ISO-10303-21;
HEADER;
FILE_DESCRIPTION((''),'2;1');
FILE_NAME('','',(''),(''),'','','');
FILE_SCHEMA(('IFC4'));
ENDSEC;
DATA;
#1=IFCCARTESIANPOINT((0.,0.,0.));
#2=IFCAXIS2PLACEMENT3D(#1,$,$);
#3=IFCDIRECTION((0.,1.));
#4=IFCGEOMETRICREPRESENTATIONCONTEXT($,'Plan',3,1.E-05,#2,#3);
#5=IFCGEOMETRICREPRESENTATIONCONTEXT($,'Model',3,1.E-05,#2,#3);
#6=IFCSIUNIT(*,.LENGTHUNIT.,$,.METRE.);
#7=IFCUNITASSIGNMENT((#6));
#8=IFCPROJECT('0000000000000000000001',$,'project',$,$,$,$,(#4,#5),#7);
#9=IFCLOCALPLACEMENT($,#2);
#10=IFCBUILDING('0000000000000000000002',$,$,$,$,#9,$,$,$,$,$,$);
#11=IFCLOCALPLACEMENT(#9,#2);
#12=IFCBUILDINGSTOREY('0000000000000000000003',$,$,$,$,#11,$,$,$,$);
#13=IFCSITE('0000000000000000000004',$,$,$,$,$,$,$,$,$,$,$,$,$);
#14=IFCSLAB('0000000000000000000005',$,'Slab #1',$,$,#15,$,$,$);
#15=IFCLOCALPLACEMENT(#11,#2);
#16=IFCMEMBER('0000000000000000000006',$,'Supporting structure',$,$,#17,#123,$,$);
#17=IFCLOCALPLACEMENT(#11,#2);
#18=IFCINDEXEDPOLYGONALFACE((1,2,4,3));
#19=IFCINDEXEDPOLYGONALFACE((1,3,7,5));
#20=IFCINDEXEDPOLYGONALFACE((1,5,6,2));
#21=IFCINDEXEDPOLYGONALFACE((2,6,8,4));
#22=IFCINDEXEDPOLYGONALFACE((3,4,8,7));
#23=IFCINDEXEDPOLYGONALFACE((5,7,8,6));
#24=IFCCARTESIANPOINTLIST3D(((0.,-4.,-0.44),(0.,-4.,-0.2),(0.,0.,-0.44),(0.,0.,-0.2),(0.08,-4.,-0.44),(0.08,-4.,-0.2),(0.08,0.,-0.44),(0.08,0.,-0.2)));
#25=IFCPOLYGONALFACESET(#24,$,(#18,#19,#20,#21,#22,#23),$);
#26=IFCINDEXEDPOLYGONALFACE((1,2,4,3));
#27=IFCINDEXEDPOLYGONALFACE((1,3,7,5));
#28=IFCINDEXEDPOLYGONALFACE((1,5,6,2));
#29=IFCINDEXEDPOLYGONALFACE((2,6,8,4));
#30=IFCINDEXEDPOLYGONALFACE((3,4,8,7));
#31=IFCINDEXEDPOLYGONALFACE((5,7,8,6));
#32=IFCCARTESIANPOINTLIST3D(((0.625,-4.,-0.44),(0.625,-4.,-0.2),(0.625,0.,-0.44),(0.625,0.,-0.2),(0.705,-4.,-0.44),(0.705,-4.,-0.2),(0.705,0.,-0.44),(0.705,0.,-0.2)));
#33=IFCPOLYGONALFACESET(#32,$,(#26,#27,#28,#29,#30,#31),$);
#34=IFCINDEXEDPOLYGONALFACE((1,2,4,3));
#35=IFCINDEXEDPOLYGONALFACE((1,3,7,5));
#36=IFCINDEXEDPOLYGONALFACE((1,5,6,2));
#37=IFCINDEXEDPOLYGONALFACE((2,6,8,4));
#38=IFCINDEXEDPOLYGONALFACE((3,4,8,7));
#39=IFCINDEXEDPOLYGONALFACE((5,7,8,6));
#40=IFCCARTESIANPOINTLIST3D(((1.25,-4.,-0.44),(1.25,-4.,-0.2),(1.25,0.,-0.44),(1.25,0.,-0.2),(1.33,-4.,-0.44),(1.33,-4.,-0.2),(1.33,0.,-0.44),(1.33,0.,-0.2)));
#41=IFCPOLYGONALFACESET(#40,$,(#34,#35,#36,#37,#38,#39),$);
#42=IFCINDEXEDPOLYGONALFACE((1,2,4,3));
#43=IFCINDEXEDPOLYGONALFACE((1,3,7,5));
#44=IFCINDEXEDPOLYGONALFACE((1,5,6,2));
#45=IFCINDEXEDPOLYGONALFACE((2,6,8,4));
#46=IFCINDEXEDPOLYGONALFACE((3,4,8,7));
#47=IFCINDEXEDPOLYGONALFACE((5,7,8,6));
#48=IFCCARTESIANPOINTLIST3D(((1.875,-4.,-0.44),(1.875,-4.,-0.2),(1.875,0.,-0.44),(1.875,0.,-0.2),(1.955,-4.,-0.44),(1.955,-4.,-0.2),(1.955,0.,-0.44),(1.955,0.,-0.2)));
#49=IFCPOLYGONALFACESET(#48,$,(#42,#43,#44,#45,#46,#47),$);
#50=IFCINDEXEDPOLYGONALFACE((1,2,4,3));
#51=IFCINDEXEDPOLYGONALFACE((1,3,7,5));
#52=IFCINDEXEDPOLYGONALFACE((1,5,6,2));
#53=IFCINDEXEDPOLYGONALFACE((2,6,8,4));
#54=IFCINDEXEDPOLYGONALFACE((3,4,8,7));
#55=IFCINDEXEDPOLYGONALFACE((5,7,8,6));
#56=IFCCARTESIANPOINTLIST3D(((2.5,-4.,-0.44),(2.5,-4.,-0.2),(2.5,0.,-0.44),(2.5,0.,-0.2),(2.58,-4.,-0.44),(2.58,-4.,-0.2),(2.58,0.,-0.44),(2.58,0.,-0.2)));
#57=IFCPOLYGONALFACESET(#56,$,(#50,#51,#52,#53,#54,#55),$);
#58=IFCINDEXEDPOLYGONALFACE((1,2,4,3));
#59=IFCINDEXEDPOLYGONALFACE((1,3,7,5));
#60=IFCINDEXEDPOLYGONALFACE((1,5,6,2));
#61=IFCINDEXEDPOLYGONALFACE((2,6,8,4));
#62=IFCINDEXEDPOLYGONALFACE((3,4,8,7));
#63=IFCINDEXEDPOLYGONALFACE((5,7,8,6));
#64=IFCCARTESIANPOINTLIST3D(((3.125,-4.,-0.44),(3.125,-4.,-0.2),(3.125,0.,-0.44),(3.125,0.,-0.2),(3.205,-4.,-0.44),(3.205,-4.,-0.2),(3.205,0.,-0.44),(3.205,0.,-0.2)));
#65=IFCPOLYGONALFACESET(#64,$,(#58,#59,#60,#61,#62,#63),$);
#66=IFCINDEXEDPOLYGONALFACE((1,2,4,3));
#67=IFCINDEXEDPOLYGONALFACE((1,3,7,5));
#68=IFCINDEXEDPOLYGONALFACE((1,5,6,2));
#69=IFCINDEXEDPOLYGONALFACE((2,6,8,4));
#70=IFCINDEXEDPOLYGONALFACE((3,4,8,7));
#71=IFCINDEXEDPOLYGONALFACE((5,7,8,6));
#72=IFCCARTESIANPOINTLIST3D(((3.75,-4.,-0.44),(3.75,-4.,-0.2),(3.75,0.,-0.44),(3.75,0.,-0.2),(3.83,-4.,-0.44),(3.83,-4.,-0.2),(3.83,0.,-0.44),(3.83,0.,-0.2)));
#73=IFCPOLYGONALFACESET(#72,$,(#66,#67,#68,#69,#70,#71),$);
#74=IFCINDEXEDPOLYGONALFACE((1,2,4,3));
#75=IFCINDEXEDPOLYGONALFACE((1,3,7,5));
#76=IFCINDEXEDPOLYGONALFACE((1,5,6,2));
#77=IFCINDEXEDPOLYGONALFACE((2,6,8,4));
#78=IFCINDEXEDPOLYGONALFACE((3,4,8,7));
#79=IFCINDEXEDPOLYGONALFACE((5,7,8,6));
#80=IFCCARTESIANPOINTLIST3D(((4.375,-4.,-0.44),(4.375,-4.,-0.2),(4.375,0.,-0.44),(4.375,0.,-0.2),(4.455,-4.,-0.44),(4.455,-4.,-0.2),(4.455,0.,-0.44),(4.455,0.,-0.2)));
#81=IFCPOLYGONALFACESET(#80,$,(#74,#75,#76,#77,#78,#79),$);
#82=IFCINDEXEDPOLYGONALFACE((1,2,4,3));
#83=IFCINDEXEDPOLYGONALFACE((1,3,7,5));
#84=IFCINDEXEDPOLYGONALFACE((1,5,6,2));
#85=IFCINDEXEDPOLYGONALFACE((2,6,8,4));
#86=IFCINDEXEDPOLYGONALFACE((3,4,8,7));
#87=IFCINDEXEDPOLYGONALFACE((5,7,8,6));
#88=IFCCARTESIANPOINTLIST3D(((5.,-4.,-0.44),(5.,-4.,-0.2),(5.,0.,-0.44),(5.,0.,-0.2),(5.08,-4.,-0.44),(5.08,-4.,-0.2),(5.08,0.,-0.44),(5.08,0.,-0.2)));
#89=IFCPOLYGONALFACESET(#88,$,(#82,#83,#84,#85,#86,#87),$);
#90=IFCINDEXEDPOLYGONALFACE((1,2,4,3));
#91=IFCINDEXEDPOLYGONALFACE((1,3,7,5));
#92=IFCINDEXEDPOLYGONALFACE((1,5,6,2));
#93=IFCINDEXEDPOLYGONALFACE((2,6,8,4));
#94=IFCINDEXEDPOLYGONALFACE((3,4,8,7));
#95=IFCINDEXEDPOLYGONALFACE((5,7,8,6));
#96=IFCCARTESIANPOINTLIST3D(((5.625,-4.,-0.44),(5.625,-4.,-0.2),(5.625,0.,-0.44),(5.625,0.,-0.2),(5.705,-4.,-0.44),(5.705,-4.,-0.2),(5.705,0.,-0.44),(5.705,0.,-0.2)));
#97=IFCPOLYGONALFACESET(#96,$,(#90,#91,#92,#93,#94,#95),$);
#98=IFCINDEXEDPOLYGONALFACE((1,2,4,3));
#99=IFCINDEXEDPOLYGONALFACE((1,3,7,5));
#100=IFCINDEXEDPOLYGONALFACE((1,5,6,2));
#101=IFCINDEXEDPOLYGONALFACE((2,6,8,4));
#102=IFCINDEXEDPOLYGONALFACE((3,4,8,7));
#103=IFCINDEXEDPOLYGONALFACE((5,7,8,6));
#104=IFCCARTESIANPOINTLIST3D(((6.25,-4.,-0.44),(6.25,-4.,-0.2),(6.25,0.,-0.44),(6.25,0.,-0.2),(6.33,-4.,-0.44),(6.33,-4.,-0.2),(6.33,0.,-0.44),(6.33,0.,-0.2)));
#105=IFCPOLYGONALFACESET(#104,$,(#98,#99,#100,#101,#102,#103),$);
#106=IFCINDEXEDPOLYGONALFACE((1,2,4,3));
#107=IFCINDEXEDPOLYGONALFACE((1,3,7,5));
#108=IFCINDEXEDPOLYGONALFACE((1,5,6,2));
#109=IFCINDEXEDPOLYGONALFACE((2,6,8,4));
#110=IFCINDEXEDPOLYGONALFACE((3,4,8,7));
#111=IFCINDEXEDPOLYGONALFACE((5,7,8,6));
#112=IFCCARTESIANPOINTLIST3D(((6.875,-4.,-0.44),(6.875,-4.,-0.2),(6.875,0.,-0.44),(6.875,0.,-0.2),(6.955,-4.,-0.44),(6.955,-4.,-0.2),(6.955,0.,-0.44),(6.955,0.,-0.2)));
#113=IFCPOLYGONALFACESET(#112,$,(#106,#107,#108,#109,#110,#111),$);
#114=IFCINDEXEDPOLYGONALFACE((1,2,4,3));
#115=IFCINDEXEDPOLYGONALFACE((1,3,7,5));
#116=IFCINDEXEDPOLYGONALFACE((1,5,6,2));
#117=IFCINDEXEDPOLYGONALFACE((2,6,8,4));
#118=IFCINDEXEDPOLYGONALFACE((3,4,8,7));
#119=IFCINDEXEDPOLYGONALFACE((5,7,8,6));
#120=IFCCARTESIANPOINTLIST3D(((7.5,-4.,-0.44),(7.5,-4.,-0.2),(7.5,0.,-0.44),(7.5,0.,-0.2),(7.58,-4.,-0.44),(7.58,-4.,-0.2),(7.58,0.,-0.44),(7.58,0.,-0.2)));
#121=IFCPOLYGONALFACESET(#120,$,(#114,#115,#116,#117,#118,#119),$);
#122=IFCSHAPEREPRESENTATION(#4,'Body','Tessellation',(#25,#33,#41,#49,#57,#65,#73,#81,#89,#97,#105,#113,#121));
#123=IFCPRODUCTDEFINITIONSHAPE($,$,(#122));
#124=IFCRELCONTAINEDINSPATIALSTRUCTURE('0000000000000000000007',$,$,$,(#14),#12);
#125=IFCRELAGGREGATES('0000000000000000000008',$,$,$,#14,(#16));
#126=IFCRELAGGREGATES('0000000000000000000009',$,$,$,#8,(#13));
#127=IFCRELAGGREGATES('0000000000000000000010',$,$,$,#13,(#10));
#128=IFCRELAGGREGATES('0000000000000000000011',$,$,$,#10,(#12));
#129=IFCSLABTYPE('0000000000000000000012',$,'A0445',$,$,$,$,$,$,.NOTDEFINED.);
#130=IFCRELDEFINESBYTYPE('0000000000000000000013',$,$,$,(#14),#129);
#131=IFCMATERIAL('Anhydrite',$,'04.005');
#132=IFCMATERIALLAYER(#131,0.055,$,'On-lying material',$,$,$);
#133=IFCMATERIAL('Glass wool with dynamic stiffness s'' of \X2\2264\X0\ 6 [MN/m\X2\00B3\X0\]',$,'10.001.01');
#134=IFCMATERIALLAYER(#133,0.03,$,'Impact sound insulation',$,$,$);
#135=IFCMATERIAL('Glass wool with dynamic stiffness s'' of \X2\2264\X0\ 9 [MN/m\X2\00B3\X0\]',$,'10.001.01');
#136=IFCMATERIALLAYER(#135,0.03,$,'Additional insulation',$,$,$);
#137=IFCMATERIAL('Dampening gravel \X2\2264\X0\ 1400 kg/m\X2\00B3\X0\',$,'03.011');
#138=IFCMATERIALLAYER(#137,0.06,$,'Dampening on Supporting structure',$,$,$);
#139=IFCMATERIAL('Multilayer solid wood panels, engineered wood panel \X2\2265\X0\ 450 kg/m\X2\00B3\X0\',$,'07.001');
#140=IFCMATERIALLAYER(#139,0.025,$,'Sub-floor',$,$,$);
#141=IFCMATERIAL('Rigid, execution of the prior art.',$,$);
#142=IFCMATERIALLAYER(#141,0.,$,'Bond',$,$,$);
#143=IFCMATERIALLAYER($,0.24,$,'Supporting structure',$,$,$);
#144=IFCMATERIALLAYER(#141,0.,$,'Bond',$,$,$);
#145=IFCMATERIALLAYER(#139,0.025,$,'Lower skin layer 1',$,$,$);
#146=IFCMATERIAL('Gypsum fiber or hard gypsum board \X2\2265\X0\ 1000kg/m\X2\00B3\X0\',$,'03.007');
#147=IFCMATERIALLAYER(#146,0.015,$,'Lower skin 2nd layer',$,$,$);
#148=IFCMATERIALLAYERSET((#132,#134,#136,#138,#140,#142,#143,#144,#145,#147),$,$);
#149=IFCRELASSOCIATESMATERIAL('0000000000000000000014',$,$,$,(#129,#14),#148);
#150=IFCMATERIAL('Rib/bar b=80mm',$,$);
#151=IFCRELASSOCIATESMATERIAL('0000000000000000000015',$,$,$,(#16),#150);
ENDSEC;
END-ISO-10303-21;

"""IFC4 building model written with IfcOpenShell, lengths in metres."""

from ifc_helpers import new_model, si_unit, direction, frame, frame_2d, origin, place, context, project, spatial, rectangle, extrude, material, layer, layer_set, type_object, element, aggregate, save


model = new_model("IFC4")

# Units and contexts
plan_context = context("Plan", 3, precision=1e-05, world=origin(), true_north=direction((0.0, 1.0)))
model_context = context("Model", 3, precision=1e-05, world=origin(), true_north=direction((0.0, 1.0)))
ifc_project = project(units=[si_unit("LENGTHUNIT", "METRE")], contexts=[plan_context, model_context])

# Site, building, storey
site = spatial("IfcSite", under=ifc_project)
building_placement = place(None, origin())
building = spatial("IfcBuilding", under=site, at=building_placement)
storey_placement = place(building_placement, origin())
storey = spatial("IfcBuildingStorey", under=building, at=storey_placement)

# Slab, member
ifc_material_1 = material(Name="Anhydrite", Category="04.005")
ifc_layer_1 = layer(ifc_material_1, 0.055, Name="On-lying material")
ifc_material_2 = material(Name="Glass wool with dynamic stiffness s' of ≤ 6 [MN/m³]", Category="10.001.01")
ifc_layer_2 = layer(ifc_material_2, 0.03, Name="Impact sound insulation")
ifc_material_3 = material(Name="Glass wool with dynamic stiffness s' of ≤ 9 [MN/m³]", Category="10.001.01")
ifc_layer_3 = layer(ifc_material_3, 0.03, Name="Additional insulation")
ifc_material_4 = material(Name="Dampening gravel ≤ 1400 kg/m³", Category="03.011")
ifc_layer_4 = layer(ifc_material_4, 0.06, Name="Dampening on Supporting structure")
ifc_material_5 = material(Name="Multilayer solid wood panels, engineered wood panel ≥ 450 kg/m³", Category="07.001")
ifc_layer_5 = layer(ifc_material_5, 0.025, Name="Sub-floor")
ifc_material_6 = material(Name="Rigid, execution of the prior art.")
ifc_layer_6 = layer(ifc_material_6, 0.0, Name="Bond")
ifc_layer_7 = layer(None, 0.24, Name="Supporting structure")
ifc_layer_8 = layer(ifc_material_6, 0.0, Name="Bond")
ifc_layer_9 = layer(ifc_material_5, 0.025, Name="Lower skin layer 1")
ifc_material_7 = material(Name="Gypsum fiber or hard gypsum board ≥ 1000kg/m³", Category="03.007")
ifc_layer_10 = layer(ifc_material_7, 0.015, Name="Lower skin 2nd layer")
ifc_layer_set = layer_set([ifc_layer_1, ifc_layer_2, ifc_layer_3, ifc_layer_4, ifc_layer_5, ifc_layer_6, ifc_layer_7, ifc_layer_8, ifc_layer_9, ifc_layer_10])
slab_type = type_object("IfcSlabType", Name="A0445", PredefinedType="NOTDEFINED", material=ifc_layer_set)
slab_placement = place(None, frame((0.0, 0.0, 0.0), z_axis=(0.0, 0.0, -1.0), x_axis=(1.0, 0.0, 0.0)))
slab = element("IfcSlab", 1, at=slab_placement, inside=storey, type_object=slab_type, material=ifc_layer_set, Name="Slab #1")
ifc_material_8 = material(Name="Rib/bar b=80mm")
member_1_placement = place(slab_placement, origin())
member_1 = element("IfcMember", 2, at=member_1_placement, material=ifc_material_8, Name="Supporting structure", context=plan_context, shape_type="SweptSolid", body=[
    extrude(rectangle(XDim=0.08, YDim=0.24, at=frame_2d((0.04, 0.12), x_axis=(1.0, 0.0))), frame((0.0, 4.0, 0.2), z_axis=(0.0, -1.0, 0.0), x_axis=(1.0, 0.0, 0.0)), (0.0, 0.0, 1.0), 4.0),
    extrude(rectangle(XDim=0.08, YDim=0.24, at=frame_2d((0.04, 0.12), x_axis=(1.0, 0.0))), frame((0.625, 4.0, 0.2), z_axis=(0.0, -1.0, 0.0), x_axis=(1.0, 0.0, 0.0)), (0.0, 0.0, 1.0), 4.0),
    extrude(rectangle(XDim=0.08, YDim=0.24, at=frame_2d((0.04, 0.12), x_axis=(1.0, 0.0))), frame((1.25, 4.0, 0.2), z_axis=(0.0, -1.0, 0.0), x_axis=(1.0, 0.0, 0.0)), (0.0, 0.0, 1.0), 4.0),
    extrude(rectangle(XDim=0.08, YDim=0.24, at=frame_2d((0.04, 0.12), x_axis=(1.0, 0.0))), frame((1.875, 4.0, 0.2), z_axis=(0.0, -1.0, 0.0), x_axis=(1.0, 0.0, 0.0)), (0.0, 0.0, 1.0), 4.0),
    extrude(rectangle(XDim=0.08, YDim=0.24, at=frame_2d((0.04, 0.12), x_axis=(1.0, 0.0))), frame((2.5, 4.0, 0.2), z_axis=(0.0, -1.0, 0.0), x_axis=(1.0, 0.0, 0.0)), (0.0, 0.0, 1.0), 4.0),
    extrude(rectangle(XDim=0.08, YDim=0.24, at=frame_2d((0.04, 0.12), x_axis=(1.0, 0.0))), frame((3.125, 4.0, 0.2), z_axis=(0.0, -1.0, 0.0), x_axis=(1.0, 0.0, 0.0)), (0.0, 0.0, 1.0), 4.0),
    extrude(rectangle(XDim=0.08, YDim=0.24, at=frame_2d((0.04, 0.12), x_axis=(1.0, 0.0))), frame((3.75, 4.0, 0.2), z_axis=(0.0, -1.0, 0.0), x_axis=(1.0, 0.0, 0.0)), (0.0, 0.0, 1.0), 4.0),
    extrude(rectangle(XDim=0.08, YDim=0.24, at=frame_2d((0.04, 0.12), x_axis=(1.0, 0.0))), frame((4.375, 4.0, 0.2), z_axis=(0.0, -1.0, 0.0), x_axis=(1.0, 0.0, 0.0)), (0.0, 0.0, 1.0), 4.0),
    extrude(rectangle(XDim=0.08, YDim=0.24, at=frame_2d((0.04, 0.12), x_axis=(1.0, 0.0))), frame((5.0, 4.0, 0.2), z_axis=(0.0, -1.0, 0.0), x_axis=(1.0, 0.0, 0.0)), (0.0, 0.0, 1.0), 4.0),
    extrude(rectangle(XDim=0.08, YDim=0.24, at=frame_2d((0.04, 0.12), x_axis=(1.0, 0.0))), frame((5.625, 4.0, 0.2), z_axis=(0.0, -1.0, 0.0), x_axis=(1.0, 0.0, 0.0)), (0.0, 0.0, 1.0), 4.0),
    extrude(rectangle(XDim=0.08, YDim=0.24, at=frame_2d((0.04, 0.12), x_axis=(1.0, 0.0))), frame((6.25, 4.0, 0.2), z_axis=(0.0, -1.0, 0.0), x_axis=(1.0, 0.0, 0.0)), (0.0, 0.0, 1.0), 4.0),
    extrude(rectangle(XDim=0.08, YDim=0.24, at=frame_2d((0.04, 0.12), x_axis=(1.0, 0.0))), frame((6.875, 4.0, 0.2), z_axis=(0.0, -1.0, 0.0), x_axis=(1.0, 0.0, 0.0)), (0.0, 0.0, 1.0), 4.0),
    extrude(rectangle(XDim=0.08, YDim=0.24, at=frame_2d((0.04, 0.12), x_axis=(1.0, 0.0))), frame((7.5, 4.0, 0.2), z_axis=(0.0, -1.0, 0.0), x_axis=(1.0, 0.0, 0.0)), (0.0, 0.0, 1.0), 4.0),
])
aggregate(slab, [member_1])

save(model, "model.ifc")
